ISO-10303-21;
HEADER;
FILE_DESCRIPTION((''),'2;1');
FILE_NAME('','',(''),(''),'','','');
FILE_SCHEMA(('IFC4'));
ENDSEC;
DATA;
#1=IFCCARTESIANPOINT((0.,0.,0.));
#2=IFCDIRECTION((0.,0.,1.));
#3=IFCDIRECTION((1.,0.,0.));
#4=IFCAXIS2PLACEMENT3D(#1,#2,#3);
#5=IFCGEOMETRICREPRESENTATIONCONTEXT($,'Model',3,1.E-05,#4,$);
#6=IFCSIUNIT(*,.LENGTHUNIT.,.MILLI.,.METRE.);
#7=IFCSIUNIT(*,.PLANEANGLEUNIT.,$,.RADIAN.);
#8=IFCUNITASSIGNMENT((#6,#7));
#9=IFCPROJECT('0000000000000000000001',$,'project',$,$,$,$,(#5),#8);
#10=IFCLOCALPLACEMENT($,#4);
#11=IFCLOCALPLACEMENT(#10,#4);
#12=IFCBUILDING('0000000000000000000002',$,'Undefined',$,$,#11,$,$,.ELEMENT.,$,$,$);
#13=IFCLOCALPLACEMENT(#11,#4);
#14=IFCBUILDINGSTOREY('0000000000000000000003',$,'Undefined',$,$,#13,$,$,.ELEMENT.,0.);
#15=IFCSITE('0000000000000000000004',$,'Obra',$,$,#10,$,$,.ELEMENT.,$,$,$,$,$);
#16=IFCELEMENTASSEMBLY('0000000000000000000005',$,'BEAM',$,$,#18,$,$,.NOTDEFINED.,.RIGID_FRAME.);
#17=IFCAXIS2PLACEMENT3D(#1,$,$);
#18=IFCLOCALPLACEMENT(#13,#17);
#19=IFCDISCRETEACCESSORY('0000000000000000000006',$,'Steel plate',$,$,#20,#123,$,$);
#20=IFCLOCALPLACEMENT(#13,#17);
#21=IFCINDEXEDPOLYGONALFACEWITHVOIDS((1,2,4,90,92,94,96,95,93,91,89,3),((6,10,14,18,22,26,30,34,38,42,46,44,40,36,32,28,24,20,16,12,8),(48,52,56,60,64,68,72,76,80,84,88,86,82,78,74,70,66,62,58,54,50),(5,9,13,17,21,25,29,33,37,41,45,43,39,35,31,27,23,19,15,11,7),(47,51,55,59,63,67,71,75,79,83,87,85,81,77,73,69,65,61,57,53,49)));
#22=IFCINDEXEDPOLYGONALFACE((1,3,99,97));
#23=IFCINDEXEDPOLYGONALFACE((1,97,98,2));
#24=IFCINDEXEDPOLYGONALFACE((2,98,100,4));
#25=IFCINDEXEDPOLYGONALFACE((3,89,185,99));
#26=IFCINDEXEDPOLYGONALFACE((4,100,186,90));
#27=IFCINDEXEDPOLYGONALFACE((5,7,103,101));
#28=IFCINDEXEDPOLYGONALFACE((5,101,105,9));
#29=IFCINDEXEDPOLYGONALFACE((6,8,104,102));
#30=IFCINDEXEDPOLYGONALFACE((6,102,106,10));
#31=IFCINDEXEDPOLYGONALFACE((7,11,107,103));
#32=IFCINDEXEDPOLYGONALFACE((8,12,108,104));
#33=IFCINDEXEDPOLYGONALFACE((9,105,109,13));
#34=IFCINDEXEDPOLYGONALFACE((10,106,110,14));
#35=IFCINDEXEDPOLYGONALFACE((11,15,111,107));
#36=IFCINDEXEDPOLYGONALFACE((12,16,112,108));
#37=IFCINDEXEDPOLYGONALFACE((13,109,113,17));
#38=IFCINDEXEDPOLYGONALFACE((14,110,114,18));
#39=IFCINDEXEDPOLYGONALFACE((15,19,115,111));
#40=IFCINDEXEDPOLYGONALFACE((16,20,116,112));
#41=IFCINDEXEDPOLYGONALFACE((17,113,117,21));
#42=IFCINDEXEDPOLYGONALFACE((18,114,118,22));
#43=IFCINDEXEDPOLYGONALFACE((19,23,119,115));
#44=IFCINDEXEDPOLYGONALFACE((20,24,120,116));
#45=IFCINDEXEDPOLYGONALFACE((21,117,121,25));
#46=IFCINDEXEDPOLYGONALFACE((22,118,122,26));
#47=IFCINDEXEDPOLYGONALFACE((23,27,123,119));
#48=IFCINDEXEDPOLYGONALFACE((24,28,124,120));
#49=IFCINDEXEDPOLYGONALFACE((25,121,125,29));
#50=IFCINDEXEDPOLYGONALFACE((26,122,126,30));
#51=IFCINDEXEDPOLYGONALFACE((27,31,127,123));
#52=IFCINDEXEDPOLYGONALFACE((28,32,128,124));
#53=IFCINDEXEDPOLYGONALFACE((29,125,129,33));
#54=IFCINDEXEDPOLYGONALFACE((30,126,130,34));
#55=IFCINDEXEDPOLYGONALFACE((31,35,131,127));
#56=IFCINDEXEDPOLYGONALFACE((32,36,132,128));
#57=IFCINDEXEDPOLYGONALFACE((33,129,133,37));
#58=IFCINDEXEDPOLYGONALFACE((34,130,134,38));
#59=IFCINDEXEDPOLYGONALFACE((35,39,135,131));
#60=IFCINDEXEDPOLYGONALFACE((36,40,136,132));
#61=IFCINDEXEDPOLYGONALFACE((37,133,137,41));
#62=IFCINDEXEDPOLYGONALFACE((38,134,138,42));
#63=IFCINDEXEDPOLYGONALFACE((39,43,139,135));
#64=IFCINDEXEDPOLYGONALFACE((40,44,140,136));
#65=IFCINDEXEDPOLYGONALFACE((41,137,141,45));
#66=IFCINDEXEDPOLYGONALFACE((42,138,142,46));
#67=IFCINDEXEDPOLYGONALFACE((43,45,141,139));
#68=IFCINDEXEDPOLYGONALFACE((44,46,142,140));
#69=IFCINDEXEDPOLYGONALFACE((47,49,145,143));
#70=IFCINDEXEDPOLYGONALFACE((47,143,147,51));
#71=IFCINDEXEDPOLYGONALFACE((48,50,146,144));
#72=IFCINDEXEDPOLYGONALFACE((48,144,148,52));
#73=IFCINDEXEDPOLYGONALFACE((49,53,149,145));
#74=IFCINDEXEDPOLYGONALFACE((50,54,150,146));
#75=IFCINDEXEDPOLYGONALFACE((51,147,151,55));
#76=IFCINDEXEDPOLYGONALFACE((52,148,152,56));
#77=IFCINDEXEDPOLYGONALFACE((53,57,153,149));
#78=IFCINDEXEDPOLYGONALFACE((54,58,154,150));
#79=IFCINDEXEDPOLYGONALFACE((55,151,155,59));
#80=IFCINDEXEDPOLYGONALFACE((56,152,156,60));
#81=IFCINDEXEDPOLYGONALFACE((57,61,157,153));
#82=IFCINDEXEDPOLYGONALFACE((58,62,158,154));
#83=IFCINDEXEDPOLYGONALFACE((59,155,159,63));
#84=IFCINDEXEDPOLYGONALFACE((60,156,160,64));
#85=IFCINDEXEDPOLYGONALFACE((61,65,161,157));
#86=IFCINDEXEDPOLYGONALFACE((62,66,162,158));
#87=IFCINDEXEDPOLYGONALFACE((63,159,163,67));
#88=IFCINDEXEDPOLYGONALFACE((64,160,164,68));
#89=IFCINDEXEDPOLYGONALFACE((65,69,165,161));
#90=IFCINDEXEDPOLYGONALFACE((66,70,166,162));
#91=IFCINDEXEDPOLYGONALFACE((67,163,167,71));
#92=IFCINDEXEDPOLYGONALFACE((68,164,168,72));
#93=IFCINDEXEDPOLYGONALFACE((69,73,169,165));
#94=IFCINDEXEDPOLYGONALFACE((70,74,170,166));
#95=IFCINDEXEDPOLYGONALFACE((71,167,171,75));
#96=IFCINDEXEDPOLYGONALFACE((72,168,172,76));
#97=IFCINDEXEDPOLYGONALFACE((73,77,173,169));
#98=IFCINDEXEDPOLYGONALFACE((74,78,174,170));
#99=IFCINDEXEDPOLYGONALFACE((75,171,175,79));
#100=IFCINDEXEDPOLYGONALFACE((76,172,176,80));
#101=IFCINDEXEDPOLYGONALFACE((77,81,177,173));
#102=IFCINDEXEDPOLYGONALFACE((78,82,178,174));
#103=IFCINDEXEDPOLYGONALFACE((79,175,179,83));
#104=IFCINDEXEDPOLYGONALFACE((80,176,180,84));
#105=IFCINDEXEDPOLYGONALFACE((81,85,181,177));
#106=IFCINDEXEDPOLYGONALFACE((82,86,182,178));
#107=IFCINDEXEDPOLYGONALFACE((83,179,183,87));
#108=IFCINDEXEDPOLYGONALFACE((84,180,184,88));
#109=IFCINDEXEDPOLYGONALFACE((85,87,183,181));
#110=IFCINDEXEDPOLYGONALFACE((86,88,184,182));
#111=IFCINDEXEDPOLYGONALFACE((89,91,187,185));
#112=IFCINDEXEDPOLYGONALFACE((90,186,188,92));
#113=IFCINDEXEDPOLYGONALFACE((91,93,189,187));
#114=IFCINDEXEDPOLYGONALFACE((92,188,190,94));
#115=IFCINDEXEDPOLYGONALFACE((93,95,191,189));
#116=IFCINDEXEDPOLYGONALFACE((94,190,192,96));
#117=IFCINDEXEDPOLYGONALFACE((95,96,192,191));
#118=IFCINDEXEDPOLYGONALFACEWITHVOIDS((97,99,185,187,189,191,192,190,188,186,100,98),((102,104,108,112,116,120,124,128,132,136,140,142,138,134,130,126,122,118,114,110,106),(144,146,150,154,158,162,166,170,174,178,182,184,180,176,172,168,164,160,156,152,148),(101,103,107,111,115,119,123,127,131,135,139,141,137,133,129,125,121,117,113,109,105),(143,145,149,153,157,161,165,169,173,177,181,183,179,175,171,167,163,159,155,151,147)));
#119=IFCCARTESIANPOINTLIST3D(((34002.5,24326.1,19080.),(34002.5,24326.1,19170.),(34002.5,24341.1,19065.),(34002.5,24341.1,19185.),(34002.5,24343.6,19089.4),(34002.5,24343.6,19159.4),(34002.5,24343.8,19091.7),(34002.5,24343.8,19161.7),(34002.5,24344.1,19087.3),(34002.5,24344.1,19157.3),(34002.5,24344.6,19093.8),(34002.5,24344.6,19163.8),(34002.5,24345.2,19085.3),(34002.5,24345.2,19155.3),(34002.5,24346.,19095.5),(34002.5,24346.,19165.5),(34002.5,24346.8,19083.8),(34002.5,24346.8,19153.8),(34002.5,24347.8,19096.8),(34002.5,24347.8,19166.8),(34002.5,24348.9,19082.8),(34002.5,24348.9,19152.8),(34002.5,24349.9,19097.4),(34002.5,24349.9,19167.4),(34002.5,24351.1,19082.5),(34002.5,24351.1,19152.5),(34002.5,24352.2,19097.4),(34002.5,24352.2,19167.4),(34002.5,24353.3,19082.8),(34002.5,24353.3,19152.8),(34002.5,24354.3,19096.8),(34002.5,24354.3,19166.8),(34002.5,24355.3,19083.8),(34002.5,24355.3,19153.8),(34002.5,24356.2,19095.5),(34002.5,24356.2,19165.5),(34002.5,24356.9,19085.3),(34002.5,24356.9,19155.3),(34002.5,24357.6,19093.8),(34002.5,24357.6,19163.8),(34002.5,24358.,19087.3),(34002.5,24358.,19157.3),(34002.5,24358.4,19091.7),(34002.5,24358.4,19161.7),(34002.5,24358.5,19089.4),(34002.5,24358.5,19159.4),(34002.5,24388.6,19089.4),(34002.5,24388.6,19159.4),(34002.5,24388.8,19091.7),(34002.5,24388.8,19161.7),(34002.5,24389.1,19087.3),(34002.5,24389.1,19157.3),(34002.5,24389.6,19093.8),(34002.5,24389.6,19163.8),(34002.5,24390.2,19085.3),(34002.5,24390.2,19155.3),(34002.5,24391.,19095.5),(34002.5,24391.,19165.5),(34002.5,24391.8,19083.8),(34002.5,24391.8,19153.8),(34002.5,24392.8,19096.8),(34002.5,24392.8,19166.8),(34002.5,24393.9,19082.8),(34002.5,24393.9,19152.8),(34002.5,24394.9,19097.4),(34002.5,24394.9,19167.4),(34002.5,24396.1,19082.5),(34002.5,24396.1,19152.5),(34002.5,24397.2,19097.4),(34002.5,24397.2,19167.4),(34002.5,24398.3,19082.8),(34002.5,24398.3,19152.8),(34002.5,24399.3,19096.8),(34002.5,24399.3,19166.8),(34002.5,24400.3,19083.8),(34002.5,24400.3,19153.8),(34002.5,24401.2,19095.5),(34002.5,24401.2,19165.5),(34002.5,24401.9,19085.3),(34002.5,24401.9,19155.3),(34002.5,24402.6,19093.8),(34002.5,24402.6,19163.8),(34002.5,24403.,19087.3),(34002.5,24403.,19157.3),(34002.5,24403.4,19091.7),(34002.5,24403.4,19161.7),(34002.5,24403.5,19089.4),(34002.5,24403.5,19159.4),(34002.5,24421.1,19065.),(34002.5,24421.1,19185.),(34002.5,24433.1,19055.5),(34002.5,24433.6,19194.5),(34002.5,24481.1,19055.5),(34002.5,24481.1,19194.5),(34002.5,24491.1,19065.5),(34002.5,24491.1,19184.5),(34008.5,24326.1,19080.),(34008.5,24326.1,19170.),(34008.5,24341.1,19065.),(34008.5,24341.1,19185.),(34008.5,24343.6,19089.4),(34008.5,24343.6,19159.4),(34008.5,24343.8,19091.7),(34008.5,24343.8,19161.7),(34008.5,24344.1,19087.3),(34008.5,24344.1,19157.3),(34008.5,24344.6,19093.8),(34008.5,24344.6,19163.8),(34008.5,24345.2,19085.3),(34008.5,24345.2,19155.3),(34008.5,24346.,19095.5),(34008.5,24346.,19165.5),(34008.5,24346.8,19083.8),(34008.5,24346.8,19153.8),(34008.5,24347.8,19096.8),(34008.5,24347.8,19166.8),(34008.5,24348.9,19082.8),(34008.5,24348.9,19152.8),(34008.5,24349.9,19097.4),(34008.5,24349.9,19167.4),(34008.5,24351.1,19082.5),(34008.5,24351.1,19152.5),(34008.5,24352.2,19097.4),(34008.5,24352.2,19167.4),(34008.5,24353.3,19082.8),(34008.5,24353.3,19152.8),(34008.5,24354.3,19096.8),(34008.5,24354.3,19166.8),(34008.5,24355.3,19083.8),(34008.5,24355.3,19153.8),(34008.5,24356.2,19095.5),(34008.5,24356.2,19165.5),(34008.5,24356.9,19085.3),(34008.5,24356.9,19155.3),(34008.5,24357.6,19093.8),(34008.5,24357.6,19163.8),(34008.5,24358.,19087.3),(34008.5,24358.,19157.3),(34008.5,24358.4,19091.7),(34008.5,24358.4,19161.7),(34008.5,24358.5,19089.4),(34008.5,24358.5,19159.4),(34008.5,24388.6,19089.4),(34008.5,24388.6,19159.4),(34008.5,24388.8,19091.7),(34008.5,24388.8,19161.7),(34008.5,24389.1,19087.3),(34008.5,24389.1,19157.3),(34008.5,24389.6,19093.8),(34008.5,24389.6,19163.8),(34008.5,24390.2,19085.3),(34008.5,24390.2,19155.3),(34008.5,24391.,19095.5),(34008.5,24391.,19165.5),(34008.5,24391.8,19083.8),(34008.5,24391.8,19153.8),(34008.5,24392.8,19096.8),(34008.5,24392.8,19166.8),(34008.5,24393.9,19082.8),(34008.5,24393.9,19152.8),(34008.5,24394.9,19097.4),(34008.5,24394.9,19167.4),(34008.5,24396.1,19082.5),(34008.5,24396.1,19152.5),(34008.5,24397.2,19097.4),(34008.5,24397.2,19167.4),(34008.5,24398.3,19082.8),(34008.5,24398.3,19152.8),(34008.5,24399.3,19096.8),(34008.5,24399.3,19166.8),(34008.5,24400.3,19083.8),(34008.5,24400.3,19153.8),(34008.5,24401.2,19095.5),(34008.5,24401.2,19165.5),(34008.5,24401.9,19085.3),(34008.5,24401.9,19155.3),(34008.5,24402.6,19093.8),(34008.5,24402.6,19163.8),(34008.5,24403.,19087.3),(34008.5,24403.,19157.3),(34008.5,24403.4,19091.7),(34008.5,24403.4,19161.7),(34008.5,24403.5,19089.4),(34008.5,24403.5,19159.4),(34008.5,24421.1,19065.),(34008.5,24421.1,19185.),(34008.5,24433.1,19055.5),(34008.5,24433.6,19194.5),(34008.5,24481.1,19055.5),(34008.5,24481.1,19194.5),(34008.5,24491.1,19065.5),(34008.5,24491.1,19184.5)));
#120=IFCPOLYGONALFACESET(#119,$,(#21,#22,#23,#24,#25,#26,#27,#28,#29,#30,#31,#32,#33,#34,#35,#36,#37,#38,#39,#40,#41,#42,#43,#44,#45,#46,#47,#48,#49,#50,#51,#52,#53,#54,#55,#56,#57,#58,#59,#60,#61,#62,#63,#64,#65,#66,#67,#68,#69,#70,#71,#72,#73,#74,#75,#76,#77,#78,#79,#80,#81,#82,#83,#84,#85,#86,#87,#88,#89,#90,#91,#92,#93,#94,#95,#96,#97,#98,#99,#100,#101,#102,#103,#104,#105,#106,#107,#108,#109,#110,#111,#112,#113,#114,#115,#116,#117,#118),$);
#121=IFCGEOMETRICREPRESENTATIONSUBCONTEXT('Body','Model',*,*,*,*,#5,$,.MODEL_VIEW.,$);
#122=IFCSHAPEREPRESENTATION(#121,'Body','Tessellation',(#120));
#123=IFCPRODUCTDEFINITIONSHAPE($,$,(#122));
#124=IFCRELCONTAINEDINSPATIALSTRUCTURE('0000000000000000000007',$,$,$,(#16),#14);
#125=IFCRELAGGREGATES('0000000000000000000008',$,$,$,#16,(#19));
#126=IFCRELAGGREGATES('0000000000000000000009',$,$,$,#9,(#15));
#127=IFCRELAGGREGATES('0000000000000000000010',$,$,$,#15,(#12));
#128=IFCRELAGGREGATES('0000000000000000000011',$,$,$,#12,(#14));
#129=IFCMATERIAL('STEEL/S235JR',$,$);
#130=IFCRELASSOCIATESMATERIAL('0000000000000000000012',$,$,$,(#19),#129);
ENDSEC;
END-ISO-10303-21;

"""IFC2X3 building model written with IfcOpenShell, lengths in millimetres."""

from ifc_helpers import new_model, si_unit, frame, origin_with_axes, origin_2d_with_axis, place, context, subcontext, project, spatial, polyline, circle, outline, extrude, source, transform, mapped, material, element, aggregate, save


model = new_model("IFC2X3")

# Units and contexts
model_context = context("Model", 3, precision=1e-05, world=origin_with_axes())
body_context = subcontext(model_context, "Body", "Model", "MODEL_VIEW")
ifc_project = project(units=[si_unit("LENGTHUNIT", "METRE", prefix="MILLI"), si_unit("PLANEANGLEUNIT", "RADIAN")], contexts=[model_context])

# Site, building, storey
site_placement = place(None, origin_with_axes())
site = spatial("IfcSite", under=ifc_project, at=site_placement, Name="Obra", CompositionType="ELEMENT")
building_placement = place(site_placement, origin_with_axes())
building = spatial("IfcBuilding", under=site, at=building_placement, Name="Undefined", CompositionType="ELEMENT")
storey_placement = place(building_placement, origin_with_axes())
storey = spatial("IfcBuildingStorey", under=building, at=storey_placement, Name="Undefined", CompositionType="ELEMENT", Elevation=0.0)

# Shared definitions
ifc_material_1 = material(Name="STEEL/S235JR")

# Element assembly
assembly_1_placement = place(storey_placement, origin_with_axes())
assembly_1 = element("IfcElementAssembly", 1, at=assembly_1_placement, inside=storey, Name="BEAM", AssemblyPlace="NOTDEFINED", PredefinedType="RIGID_FRAME")

# Shared definitions
shared_shape_1 = source(origin_with_axes(), body_context, "Body", "SweptSolid", [
    extrude(circle(Radius=7.5, at=origin_2d_with_axis()), frame((0.0, 2.4, 0.0), z_axis=(0.0, 1.0, 0.0), x_axis=(1.0, 0.0, 0.0)), (0.0, 0.0, 1.0), 6.2),
])

# Discrete accessory, opening
discrete_accessory_1_placement = place(assembly_1_placement, frame((34005.5, 24491.1, 19065.5), z_axis=(-1.0, 0.0, 0.0), x_axis=(0.000001, -0.707107, -0.707107)))
discrete_accessory_1 = element("IfcDiscreteAccessory", 2, at=discrete_accessory_1_placement, material=ifc_material_1, Name="Steel plate", context=body_context, shape_type="SweptSolid", body=[
    extrude(outline(polyline([(0.0, 0.0), (14.1, 0.0), (48.1, 33.9), (49.9, 49.1), (106.4, 105.7), (106.4, 126.9), (42.8, 190.6), (21.6, 190.6), (-35.0, 134.0), (-50.6, 131.9), (-84.1, 98.3), (-84.1, 84.1), (0.0, 0.0)])), frame((0.0, 0.0, -3.0), z_axis=(0.0, 0.0, 1.0), x_axis=(1.0, 0.0, 0.0)), (0.0, 0.0, 1.0), 6.0),
])
opening_1_placement = place(assembly_1_placement, frame((34000.0, 24373.6, 19160.0), z_axis=(0.0, -1.0, 0.0), x_axis=(0.0, 0.0, -1.0)))
element("IfcOpeningElement", 3, at=opening_1_placement, cuts=discrete_accessory_1, ObjectType="Opening", context=body_context, shape_type="MappedRepresentation", body=[
    mapped(shared_shape_1, transform((0.0, 0.0, -22.5))),
    mapped(shared_shape_1, transform((70.0, 0.0, -22.5))),
    mapped(shared_shape_1, transform((0.0, 0.0, 22.5))),
    mapped(shared_shape_1, transform((70.0, 0.0, 22.5))),
])

aggregate(assembly_1, [discrete_accessory_1])

save(model, "model.ifc")
